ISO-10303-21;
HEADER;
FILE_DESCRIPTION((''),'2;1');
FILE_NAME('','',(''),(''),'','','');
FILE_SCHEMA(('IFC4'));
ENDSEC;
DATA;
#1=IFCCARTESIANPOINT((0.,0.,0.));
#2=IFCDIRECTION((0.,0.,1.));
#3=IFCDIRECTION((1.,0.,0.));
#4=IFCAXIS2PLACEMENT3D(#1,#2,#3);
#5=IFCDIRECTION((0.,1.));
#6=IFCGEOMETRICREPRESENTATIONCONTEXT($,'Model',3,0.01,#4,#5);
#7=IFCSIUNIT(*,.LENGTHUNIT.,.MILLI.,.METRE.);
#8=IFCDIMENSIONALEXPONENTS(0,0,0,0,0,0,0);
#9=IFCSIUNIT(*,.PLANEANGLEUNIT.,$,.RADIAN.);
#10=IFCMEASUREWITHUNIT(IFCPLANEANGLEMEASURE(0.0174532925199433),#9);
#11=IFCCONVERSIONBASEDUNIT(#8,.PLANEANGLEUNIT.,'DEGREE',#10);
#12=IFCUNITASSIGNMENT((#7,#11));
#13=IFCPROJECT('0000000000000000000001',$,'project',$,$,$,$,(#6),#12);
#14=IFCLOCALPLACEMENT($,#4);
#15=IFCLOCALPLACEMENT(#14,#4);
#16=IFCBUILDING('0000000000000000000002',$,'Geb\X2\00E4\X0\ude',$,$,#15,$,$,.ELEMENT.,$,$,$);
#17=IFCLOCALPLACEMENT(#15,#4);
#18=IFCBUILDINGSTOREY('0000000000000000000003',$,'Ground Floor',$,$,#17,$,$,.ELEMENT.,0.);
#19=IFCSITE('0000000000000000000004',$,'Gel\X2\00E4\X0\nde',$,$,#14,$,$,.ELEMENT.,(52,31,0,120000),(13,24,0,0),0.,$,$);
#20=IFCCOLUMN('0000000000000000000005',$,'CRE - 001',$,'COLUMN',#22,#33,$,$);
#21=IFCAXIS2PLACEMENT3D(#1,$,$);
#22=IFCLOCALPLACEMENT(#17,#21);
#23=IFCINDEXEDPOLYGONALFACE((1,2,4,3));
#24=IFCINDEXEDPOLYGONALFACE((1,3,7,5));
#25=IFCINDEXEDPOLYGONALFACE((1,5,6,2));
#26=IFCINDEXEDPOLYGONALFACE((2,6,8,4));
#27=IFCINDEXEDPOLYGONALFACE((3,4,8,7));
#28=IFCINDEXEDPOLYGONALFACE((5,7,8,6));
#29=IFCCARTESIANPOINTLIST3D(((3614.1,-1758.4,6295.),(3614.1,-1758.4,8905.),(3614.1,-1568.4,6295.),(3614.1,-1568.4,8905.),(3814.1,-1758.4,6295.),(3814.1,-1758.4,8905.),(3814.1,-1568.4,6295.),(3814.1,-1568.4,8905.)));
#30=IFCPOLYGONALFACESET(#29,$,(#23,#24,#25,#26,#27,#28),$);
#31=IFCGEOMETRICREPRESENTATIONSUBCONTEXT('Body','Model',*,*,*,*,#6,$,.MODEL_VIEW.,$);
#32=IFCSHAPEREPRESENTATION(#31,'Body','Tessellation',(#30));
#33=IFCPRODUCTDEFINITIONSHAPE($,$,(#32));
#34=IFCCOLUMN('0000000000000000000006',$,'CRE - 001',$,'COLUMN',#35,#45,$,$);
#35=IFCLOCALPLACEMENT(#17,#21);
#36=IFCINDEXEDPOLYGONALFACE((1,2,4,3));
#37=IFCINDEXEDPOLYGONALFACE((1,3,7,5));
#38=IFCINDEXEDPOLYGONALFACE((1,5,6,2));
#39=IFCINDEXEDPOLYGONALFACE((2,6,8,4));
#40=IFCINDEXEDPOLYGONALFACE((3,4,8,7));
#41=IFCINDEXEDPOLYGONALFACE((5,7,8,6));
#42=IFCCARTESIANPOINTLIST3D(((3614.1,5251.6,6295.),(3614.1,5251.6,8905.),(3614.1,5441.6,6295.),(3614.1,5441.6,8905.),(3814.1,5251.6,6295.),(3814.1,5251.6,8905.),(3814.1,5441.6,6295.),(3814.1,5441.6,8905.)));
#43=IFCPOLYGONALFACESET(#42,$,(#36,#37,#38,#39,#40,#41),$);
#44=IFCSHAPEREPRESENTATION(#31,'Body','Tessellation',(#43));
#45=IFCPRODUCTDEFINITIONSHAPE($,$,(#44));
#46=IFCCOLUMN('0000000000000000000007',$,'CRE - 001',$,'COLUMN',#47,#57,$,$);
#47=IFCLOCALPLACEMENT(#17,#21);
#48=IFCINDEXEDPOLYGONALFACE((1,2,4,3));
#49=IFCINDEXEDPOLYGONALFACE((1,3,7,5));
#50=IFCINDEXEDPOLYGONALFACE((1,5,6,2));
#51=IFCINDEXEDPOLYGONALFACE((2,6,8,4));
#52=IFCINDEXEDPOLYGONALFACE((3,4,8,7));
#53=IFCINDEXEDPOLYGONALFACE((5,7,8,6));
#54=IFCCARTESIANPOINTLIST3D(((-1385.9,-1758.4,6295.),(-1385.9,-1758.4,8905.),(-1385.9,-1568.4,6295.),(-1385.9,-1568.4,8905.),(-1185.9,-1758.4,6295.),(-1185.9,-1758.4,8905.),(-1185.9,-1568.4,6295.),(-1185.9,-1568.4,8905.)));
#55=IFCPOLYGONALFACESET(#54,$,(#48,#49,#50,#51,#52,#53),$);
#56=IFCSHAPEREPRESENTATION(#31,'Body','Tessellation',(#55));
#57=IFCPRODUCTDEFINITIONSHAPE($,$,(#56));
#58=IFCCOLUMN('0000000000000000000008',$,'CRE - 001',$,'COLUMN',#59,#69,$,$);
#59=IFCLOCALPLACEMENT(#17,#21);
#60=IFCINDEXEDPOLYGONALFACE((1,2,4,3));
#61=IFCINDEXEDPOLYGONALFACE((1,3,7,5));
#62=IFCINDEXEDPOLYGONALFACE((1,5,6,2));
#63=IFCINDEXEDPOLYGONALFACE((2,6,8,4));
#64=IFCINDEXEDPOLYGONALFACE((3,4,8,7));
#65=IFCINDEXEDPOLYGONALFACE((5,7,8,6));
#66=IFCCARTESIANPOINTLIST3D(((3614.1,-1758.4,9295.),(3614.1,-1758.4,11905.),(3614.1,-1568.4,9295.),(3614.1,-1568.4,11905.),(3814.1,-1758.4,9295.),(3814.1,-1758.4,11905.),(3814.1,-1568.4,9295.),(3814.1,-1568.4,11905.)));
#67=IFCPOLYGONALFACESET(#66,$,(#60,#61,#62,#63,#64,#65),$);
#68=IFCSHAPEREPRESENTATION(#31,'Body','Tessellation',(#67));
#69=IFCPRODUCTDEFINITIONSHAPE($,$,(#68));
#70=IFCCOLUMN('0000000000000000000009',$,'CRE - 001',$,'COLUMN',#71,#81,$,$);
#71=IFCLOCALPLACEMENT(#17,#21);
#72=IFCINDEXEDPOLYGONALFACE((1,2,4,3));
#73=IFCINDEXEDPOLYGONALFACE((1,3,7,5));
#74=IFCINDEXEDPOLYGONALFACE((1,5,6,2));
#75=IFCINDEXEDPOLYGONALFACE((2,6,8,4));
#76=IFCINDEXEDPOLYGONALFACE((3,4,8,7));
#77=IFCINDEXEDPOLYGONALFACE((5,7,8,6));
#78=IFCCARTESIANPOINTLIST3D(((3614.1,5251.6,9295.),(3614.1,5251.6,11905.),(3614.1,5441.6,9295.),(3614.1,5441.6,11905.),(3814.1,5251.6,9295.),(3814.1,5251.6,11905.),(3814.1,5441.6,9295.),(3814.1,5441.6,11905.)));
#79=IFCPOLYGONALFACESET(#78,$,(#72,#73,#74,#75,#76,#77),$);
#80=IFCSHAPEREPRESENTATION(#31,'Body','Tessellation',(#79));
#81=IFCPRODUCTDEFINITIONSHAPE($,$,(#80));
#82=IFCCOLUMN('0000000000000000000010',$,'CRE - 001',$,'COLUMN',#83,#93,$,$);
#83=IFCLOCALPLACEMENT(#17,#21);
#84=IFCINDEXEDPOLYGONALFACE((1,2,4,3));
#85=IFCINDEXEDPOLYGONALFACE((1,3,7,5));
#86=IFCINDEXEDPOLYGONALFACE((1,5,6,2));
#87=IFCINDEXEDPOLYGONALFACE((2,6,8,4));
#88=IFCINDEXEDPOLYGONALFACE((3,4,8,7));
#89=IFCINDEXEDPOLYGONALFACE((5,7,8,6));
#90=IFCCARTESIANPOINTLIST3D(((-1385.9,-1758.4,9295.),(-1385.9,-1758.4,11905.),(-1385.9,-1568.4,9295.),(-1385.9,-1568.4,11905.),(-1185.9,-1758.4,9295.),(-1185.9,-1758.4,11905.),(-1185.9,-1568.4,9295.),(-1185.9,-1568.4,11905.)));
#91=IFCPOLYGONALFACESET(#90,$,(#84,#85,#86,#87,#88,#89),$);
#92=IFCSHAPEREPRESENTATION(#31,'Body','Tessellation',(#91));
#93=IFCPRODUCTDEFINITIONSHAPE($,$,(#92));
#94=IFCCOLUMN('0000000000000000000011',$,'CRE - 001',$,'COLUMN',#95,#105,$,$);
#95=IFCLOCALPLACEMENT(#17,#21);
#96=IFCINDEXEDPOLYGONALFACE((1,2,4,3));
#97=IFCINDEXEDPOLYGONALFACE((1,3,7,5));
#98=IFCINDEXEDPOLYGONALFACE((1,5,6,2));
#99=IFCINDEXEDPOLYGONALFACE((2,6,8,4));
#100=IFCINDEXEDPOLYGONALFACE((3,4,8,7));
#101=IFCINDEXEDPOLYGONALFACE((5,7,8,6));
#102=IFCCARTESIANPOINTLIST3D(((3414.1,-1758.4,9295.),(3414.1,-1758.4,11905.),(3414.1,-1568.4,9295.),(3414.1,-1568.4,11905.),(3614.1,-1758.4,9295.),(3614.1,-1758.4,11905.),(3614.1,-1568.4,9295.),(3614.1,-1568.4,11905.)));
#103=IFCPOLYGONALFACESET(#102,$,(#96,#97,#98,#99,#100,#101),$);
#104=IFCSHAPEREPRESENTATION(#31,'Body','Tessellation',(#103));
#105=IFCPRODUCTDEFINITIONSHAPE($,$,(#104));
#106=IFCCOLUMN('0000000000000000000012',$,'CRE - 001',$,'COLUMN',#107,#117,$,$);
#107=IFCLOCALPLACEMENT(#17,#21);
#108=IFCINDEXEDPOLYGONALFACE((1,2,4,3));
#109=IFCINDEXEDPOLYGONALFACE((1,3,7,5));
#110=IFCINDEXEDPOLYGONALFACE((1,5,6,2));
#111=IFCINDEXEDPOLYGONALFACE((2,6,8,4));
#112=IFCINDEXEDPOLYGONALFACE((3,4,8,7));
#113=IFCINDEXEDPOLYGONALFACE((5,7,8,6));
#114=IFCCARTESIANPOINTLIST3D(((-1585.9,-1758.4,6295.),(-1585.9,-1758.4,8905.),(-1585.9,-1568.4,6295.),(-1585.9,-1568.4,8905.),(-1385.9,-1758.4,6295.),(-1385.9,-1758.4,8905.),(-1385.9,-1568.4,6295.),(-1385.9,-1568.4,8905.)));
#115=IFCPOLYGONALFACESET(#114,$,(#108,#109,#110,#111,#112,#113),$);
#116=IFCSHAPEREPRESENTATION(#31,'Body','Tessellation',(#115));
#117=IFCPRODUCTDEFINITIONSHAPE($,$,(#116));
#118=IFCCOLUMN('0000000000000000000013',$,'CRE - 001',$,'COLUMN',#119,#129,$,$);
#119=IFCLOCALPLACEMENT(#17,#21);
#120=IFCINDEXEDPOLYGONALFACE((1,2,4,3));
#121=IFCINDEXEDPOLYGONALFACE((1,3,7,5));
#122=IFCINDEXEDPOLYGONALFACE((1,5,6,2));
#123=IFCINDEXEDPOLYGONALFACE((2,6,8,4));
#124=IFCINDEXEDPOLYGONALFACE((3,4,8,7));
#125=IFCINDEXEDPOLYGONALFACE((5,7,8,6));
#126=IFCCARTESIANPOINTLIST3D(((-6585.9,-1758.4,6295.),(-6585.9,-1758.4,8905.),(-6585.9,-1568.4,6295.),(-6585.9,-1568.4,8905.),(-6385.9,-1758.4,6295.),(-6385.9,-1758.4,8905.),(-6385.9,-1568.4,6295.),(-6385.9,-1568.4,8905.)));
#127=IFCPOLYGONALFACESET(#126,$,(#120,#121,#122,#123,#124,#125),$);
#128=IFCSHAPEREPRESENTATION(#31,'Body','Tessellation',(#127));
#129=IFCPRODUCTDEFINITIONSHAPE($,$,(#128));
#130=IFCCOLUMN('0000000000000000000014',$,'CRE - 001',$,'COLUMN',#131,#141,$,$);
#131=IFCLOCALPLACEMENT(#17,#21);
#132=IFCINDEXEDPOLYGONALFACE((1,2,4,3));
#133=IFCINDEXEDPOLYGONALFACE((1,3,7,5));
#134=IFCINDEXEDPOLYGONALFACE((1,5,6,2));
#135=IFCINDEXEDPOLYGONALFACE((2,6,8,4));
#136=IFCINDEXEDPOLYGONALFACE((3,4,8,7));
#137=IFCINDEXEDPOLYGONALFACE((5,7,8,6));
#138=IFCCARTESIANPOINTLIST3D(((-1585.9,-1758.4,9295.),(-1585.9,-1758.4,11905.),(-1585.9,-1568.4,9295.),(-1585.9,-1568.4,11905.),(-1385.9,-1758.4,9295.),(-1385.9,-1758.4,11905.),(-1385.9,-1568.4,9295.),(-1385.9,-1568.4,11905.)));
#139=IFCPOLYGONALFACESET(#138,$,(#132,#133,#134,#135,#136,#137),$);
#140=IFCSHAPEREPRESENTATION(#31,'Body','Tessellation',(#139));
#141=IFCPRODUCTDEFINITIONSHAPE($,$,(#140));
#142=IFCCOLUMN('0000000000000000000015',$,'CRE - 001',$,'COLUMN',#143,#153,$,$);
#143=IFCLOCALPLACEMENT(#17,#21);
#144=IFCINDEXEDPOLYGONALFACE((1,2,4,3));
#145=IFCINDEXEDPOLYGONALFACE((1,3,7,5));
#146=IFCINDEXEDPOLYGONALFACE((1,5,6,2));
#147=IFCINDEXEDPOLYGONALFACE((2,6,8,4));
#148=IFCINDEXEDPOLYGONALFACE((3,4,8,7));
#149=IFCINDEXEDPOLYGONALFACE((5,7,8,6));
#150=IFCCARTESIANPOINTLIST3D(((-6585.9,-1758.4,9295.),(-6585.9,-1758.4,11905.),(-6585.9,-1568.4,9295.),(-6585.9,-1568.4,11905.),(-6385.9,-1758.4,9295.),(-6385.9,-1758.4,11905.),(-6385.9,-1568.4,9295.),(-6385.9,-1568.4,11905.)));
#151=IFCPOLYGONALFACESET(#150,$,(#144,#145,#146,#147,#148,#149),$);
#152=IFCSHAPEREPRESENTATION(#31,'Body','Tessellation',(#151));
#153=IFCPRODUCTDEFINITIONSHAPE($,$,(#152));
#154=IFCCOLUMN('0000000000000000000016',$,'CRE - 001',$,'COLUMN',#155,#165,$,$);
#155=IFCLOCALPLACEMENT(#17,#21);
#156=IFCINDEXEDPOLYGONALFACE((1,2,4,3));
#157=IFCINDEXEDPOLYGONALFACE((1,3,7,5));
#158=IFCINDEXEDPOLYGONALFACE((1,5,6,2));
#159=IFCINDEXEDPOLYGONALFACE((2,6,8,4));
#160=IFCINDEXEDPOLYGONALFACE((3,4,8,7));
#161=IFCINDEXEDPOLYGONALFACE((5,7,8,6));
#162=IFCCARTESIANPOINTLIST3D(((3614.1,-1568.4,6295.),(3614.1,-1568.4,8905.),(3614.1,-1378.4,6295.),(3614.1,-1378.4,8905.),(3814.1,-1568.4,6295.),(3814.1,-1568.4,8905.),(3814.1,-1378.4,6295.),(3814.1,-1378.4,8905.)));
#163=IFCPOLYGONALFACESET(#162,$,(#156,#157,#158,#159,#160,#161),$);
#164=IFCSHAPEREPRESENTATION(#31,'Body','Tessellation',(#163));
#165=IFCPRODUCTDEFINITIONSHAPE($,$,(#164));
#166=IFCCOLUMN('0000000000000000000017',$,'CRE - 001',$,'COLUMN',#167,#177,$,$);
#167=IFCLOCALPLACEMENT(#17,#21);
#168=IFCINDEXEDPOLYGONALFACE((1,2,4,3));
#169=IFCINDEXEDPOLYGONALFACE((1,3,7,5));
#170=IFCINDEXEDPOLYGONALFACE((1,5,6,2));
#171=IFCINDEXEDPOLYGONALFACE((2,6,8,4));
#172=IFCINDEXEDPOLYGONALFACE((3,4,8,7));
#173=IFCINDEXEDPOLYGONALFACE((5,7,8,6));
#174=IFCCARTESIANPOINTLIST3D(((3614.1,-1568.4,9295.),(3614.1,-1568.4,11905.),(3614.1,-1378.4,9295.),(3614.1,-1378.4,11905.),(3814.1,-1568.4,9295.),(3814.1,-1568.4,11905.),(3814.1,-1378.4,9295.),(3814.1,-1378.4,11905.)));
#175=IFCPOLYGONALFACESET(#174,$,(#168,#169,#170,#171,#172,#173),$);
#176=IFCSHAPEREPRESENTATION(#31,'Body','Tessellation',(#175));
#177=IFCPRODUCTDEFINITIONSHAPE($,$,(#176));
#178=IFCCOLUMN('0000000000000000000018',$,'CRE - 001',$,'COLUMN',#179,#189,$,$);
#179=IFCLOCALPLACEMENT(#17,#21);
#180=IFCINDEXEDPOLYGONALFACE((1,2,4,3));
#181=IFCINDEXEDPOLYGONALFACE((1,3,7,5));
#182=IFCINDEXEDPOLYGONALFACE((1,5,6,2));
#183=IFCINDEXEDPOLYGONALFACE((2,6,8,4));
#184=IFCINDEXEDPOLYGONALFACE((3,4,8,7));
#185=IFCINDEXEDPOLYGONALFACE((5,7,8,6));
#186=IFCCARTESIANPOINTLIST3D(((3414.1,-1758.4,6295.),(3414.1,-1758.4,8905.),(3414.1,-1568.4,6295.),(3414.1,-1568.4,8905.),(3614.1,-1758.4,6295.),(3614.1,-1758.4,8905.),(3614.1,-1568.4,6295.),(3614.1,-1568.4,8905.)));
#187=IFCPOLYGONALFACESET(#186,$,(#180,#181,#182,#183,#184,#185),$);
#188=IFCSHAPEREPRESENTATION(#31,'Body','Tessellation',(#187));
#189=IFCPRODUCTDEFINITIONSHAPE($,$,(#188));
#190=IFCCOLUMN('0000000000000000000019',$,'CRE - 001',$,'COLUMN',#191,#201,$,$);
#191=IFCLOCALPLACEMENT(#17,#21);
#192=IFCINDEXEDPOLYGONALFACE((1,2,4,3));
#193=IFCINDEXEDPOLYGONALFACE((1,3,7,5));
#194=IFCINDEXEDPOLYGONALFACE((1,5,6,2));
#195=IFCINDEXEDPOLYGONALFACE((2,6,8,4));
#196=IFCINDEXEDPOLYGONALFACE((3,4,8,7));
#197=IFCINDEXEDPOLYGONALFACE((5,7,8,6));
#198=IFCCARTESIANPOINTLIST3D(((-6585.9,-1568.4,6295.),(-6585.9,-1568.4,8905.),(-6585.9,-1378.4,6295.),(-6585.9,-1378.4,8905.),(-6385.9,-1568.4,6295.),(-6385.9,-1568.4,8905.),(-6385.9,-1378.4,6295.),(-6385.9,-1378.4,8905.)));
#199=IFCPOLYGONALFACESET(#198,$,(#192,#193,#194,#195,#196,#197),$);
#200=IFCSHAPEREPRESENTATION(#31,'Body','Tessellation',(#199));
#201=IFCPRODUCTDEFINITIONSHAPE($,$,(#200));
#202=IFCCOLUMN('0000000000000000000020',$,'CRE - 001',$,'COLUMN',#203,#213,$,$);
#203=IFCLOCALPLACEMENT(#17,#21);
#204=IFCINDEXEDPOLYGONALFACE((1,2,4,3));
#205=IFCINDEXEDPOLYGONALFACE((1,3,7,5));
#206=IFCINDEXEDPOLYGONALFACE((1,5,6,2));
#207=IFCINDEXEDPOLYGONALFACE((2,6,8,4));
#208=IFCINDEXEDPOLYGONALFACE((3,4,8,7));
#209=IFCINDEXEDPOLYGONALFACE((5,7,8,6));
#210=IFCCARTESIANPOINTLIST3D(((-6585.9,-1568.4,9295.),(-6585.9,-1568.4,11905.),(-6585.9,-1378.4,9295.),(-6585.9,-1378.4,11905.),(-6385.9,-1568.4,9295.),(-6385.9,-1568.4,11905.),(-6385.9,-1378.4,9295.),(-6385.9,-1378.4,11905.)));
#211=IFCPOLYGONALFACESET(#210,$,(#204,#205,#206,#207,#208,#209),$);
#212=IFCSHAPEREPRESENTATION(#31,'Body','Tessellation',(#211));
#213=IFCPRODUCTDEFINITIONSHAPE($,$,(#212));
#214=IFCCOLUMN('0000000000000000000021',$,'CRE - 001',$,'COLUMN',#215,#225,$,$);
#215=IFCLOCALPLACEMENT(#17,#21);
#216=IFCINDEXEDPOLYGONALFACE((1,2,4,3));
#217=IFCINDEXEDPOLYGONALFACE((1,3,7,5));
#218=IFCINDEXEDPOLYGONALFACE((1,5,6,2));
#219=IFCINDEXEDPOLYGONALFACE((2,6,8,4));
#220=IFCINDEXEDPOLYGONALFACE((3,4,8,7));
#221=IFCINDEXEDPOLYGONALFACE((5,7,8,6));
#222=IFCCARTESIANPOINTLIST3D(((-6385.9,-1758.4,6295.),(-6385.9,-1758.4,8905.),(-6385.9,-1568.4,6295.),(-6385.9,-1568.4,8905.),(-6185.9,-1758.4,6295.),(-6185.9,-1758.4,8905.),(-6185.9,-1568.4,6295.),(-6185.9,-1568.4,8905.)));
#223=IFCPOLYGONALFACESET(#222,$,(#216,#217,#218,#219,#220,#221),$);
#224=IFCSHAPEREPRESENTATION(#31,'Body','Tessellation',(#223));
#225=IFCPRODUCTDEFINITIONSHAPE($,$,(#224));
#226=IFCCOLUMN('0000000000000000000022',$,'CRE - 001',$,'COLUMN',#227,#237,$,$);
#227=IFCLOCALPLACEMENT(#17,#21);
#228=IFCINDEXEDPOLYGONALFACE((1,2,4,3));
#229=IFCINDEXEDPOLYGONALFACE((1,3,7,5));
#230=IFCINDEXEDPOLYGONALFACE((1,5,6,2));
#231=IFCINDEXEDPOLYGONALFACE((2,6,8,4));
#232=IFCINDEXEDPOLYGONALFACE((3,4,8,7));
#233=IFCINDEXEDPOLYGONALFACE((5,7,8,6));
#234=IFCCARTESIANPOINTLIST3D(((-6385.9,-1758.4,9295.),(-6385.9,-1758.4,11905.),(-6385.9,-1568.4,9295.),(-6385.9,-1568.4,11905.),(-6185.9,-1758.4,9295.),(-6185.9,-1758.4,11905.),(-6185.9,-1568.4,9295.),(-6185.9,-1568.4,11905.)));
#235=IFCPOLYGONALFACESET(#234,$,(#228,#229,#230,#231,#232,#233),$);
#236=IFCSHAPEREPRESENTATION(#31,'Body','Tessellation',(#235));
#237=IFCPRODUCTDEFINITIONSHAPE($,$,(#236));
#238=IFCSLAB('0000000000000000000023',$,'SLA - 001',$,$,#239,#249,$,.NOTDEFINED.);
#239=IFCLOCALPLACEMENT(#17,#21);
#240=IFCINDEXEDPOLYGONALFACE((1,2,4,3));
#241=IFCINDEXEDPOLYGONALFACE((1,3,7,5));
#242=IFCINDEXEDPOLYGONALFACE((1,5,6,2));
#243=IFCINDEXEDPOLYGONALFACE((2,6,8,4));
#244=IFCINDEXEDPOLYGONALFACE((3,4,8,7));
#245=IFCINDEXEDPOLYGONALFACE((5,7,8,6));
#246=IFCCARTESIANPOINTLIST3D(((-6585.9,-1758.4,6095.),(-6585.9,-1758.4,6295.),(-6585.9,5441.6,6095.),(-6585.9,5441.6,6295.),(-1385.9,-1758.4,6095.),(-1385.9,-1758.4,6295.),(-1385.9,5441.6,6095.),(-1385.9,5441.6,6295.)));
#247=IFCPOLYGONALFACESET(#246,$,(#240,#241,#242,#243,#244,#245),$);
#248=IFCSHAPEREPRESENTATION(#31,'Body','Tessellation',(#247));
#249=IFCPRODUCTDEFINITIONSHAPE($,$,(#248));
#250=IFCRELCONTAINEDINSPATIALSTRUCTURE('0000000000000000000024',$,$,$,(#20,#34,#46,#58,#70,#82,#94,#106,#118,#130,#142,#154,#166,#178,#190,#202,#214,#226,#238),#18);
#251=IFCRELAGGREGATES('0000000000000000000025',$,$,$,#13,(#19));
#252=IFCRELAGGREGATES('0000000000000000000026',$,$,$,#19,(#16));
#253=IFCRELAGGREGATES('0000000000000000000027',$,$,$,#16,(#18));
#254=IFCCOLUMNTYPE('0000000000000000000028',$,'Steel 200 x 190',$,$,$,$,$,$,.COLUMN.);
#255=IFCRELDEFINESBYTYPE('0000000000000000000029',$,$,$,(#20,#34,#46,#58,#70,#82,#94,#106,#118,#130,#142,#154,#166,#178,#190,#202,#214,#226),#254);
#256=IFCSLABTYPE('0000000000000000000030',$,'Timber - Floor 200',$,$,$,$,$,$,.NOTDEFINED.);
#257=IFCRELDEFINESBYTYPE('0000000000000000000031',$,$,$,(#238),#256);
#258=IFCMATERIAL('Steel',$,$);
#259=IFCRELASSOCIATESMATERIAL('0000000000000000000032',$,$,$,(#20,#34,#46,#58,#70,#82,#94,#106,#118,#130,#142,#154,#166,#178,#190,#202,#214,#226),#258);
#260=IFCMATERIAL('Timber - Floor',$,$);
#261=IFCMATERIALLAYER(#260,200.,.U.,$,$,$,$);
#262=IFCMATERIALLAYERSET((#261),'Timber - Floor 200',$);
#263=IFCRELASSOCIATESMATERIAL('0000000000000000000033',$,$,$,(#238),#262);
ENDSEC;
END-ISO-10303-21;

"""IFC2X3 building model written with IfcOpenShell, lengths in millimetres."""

from ifc_helpers import new_model, entity, si_unit, converted_unit, direction, frame, origin_with_axes, origin_2d_with_axis, place, context, subcontext, project, spatial, polyline, rectangle, outline, extrude, material, layer, layer_set, layer_usage, type_object, element, save


model = new_model("IFC2X3")

# Units and contexts
model_context = context("Model", 3, precision=0.01, world=origin_with_axes(), true_north=direction((0.0, 1.0)))
body_context = subcontext(model_context, "Body", "Model", "MODEL_VIEW")
ifc_project = project(units=[si_unit("LENGTHUNIT", "METRE", prefix="MILLI"), converted_unit("PLANEANGLEUNIT", "DEGREE", entity("IfcPlaneAngleMeasure", 0.0174532925199433), si_unit("PLANEANGLEUNIT", "RADIAN"), dimensions=[0, 0, 0, 0, 0, 0, 0])], contexts=[model_context])

# Site, building, storey
site_placement = place(None, origin_with_axes())
site = spatial("IfcSite", under=ifc_project, at=site_placement, Name="Gelände", CompositionType="ELEMENT", RefLatitude=(52, 31, 0, 120000), RefLongitude=(13, 24, 0, 0), RefElevation=0.0)
building_placement = place(site_placement, origin_with_axes())
building = spatial("IfcBuilding", under=site, at=building_placement, Name="Gebäude", CompositionType="ELEMENT")
storey_placement = place(building_placement, origin_with_axes())
storey = spatial("IfcBuildingStorey", under=building, at=storey_placement, Name="Ground Floor", CompositionType="ELEMENT", Elevation=0.0)

# Columns
ifc_material_1 = material(Name="Steel")
column_type = type_object("IfcColumnType", Name="Steel 200 x 190", PredefinedType="COLUMN")
for number, where, z_axis, x_axis, name in (
    (1, (3714.1, -1663.4, 6295.0), (0.0, 0.0, 1.0), (1.0, 0.0, 0.0), "CRE - 001"),
    (2, (3714.1, 5346.6, 6295.0), (0.0, 0.0, 1.0), (1.0, 0.0, 0.0), "CRE - 001"),
    (3, (-1285.9, -1663.4, 6295.0), (0.0, 0.0, 1.0), (1.0, 0.0, 0.0), "CRE - 001"),
    (4, (3714.1, -1663.4, 9295.0), (0.0, 0.0, 1.0), (1.0, 0.0, 0.0), "CRE - 001"),
    (5, (3714.1, 5346.6, 9295.0), (0.0, 0.0, 1.0), (1.0, 0.0, 0.0), "CRE - 001"),
    (6, (-1285.9, -1663.4, 9295.0), (0.0, 0.0, 1.0), (1.0, 0.0, 0.0), "CRE - 001"),
    (7, (3514.1, -1663.4, 9295.0), (0.0, 0.0, 1.0), (1.0, 0.0, 0.0), "CRE - 001"),
    (8, (-1485.9, -1663.4, 6295.0), (0.0, 0.0, 1.0), (1.0, 0.0, 0.0), "CRE - 001"),
    (9, (-6485.9, -1663.4, 6295.0), (0.0, 0.0, 1.0), (1.0, 0.0, 0.0), "CRE - 001"),
    (10, (-1485.9, -1663.4, 9295.0), (0.0, 0.0, 1.0), (1.0, 0.0, 0.0), "CRE - 001"),
    (11, (-6485.9, -1663.4, 9295.0), (0.0, 0.0, 1.0), (1.0, 0.0, 0.0), "CRE - 001"),
    (12, (3714.1, -1473.4, 6295.0), (0.0, 0.0, 1.0), (1.0, 0.0, 0.0), "CRE - 001"),
    (13, (3714.1, -1473.4, 9295.0), (0.0, 0.0, 1.0), (1.0, 0.0, 0.0), "CRE - 001"),
    (14, (3514.1, -1663.4, 6295.0), (0.0, 0.0, 1.0), (1.0, 0.0, 0.0), "CRE - 001"),
    (15, (-6485.9, -1473.4, 6295.0), (0.0, 0.0, 1.0), (1.0, 0.0, 0.0), "CRE - 001"),
    (16, (-6485.9, -1473.4, 9295.0), (0.0, 0.0, 1.0), (1.0, 0.0, 0.0), "CRE - 001"),
    (17, (-6285.9, -1663.4, 6295.0), (0.0, 0.0, 1.0), (1.0, 0.0, 0.0), "CRE - 001"),
    (18, (-6285.9, -1663.4, 9295.0), (0.0, 0.0, 1.0), (1.0, 0.0, 0.0), "CRE - 001"),
):
    element("IfcColumn", number, at=place(storey_placement, frame(where, z_axis=z_axis, x_axis=x_axis)), inside=storey, type_object=column_type, material=ifc_material_1, Name=name, ObjectType="COLUMN", context=body_context, shape_type="SweptSolid", body=[
        extrude(rectangle(XDim=200.0, YDim=190.0, at=origin_2d_with_axis()), origin_with_axes(), (0.0, 0.0, 1.0), 2610.0),
    ])

# Slab
ifc_material_2 = material(Name="Timber - Floor")
ifc_layer_1 = layer(ifc_material_2, 200.0, ventilated="UNKNOWN")
ifc_layer_set_1 = layer_set([ifc_layer_1], Name="Timber - Floor 200")
ifc_layer_usage_1 = layer_usage(ifc_layer_set_1, "AXIS3", "NEGATIVE", 200.0)
slab_type_1 = type_object("IfcSlabType", Name="Timber - Floor 200", PredefinedType="NOTDEFINED")
slab_1_placement = place(storey_placement, frame((-6585.9, -1758.4, 6295.0), z_axis=(0.0, 0.0, 1.0), x_axis=(1.0, 0.0, 0.0)))
element("IfcSlab", 19, at=slab_1_placement, inside=storey, type_object=slab_type_1, material=ifc_layer_usage_1, Name="SLA - 001", PredefinedType="NOTDEFINED", context=body_context, shape_type="SweptSolid", body=[
    extrude(outline(polyline([(0.0, 0.0), (5200.0, 0.0), (5200.0, 7200.0), (0.0, 7200.0), (0.0, 0.0)])), frame((0.0, 0.0, -200.0), z_axis=(0.0, 0.0, 1.0), x_axis=(1.0, 0.0, 0.0)), (0.0, 0.0, 1.0), 200.0),
])

save(model, "model.ifc")
